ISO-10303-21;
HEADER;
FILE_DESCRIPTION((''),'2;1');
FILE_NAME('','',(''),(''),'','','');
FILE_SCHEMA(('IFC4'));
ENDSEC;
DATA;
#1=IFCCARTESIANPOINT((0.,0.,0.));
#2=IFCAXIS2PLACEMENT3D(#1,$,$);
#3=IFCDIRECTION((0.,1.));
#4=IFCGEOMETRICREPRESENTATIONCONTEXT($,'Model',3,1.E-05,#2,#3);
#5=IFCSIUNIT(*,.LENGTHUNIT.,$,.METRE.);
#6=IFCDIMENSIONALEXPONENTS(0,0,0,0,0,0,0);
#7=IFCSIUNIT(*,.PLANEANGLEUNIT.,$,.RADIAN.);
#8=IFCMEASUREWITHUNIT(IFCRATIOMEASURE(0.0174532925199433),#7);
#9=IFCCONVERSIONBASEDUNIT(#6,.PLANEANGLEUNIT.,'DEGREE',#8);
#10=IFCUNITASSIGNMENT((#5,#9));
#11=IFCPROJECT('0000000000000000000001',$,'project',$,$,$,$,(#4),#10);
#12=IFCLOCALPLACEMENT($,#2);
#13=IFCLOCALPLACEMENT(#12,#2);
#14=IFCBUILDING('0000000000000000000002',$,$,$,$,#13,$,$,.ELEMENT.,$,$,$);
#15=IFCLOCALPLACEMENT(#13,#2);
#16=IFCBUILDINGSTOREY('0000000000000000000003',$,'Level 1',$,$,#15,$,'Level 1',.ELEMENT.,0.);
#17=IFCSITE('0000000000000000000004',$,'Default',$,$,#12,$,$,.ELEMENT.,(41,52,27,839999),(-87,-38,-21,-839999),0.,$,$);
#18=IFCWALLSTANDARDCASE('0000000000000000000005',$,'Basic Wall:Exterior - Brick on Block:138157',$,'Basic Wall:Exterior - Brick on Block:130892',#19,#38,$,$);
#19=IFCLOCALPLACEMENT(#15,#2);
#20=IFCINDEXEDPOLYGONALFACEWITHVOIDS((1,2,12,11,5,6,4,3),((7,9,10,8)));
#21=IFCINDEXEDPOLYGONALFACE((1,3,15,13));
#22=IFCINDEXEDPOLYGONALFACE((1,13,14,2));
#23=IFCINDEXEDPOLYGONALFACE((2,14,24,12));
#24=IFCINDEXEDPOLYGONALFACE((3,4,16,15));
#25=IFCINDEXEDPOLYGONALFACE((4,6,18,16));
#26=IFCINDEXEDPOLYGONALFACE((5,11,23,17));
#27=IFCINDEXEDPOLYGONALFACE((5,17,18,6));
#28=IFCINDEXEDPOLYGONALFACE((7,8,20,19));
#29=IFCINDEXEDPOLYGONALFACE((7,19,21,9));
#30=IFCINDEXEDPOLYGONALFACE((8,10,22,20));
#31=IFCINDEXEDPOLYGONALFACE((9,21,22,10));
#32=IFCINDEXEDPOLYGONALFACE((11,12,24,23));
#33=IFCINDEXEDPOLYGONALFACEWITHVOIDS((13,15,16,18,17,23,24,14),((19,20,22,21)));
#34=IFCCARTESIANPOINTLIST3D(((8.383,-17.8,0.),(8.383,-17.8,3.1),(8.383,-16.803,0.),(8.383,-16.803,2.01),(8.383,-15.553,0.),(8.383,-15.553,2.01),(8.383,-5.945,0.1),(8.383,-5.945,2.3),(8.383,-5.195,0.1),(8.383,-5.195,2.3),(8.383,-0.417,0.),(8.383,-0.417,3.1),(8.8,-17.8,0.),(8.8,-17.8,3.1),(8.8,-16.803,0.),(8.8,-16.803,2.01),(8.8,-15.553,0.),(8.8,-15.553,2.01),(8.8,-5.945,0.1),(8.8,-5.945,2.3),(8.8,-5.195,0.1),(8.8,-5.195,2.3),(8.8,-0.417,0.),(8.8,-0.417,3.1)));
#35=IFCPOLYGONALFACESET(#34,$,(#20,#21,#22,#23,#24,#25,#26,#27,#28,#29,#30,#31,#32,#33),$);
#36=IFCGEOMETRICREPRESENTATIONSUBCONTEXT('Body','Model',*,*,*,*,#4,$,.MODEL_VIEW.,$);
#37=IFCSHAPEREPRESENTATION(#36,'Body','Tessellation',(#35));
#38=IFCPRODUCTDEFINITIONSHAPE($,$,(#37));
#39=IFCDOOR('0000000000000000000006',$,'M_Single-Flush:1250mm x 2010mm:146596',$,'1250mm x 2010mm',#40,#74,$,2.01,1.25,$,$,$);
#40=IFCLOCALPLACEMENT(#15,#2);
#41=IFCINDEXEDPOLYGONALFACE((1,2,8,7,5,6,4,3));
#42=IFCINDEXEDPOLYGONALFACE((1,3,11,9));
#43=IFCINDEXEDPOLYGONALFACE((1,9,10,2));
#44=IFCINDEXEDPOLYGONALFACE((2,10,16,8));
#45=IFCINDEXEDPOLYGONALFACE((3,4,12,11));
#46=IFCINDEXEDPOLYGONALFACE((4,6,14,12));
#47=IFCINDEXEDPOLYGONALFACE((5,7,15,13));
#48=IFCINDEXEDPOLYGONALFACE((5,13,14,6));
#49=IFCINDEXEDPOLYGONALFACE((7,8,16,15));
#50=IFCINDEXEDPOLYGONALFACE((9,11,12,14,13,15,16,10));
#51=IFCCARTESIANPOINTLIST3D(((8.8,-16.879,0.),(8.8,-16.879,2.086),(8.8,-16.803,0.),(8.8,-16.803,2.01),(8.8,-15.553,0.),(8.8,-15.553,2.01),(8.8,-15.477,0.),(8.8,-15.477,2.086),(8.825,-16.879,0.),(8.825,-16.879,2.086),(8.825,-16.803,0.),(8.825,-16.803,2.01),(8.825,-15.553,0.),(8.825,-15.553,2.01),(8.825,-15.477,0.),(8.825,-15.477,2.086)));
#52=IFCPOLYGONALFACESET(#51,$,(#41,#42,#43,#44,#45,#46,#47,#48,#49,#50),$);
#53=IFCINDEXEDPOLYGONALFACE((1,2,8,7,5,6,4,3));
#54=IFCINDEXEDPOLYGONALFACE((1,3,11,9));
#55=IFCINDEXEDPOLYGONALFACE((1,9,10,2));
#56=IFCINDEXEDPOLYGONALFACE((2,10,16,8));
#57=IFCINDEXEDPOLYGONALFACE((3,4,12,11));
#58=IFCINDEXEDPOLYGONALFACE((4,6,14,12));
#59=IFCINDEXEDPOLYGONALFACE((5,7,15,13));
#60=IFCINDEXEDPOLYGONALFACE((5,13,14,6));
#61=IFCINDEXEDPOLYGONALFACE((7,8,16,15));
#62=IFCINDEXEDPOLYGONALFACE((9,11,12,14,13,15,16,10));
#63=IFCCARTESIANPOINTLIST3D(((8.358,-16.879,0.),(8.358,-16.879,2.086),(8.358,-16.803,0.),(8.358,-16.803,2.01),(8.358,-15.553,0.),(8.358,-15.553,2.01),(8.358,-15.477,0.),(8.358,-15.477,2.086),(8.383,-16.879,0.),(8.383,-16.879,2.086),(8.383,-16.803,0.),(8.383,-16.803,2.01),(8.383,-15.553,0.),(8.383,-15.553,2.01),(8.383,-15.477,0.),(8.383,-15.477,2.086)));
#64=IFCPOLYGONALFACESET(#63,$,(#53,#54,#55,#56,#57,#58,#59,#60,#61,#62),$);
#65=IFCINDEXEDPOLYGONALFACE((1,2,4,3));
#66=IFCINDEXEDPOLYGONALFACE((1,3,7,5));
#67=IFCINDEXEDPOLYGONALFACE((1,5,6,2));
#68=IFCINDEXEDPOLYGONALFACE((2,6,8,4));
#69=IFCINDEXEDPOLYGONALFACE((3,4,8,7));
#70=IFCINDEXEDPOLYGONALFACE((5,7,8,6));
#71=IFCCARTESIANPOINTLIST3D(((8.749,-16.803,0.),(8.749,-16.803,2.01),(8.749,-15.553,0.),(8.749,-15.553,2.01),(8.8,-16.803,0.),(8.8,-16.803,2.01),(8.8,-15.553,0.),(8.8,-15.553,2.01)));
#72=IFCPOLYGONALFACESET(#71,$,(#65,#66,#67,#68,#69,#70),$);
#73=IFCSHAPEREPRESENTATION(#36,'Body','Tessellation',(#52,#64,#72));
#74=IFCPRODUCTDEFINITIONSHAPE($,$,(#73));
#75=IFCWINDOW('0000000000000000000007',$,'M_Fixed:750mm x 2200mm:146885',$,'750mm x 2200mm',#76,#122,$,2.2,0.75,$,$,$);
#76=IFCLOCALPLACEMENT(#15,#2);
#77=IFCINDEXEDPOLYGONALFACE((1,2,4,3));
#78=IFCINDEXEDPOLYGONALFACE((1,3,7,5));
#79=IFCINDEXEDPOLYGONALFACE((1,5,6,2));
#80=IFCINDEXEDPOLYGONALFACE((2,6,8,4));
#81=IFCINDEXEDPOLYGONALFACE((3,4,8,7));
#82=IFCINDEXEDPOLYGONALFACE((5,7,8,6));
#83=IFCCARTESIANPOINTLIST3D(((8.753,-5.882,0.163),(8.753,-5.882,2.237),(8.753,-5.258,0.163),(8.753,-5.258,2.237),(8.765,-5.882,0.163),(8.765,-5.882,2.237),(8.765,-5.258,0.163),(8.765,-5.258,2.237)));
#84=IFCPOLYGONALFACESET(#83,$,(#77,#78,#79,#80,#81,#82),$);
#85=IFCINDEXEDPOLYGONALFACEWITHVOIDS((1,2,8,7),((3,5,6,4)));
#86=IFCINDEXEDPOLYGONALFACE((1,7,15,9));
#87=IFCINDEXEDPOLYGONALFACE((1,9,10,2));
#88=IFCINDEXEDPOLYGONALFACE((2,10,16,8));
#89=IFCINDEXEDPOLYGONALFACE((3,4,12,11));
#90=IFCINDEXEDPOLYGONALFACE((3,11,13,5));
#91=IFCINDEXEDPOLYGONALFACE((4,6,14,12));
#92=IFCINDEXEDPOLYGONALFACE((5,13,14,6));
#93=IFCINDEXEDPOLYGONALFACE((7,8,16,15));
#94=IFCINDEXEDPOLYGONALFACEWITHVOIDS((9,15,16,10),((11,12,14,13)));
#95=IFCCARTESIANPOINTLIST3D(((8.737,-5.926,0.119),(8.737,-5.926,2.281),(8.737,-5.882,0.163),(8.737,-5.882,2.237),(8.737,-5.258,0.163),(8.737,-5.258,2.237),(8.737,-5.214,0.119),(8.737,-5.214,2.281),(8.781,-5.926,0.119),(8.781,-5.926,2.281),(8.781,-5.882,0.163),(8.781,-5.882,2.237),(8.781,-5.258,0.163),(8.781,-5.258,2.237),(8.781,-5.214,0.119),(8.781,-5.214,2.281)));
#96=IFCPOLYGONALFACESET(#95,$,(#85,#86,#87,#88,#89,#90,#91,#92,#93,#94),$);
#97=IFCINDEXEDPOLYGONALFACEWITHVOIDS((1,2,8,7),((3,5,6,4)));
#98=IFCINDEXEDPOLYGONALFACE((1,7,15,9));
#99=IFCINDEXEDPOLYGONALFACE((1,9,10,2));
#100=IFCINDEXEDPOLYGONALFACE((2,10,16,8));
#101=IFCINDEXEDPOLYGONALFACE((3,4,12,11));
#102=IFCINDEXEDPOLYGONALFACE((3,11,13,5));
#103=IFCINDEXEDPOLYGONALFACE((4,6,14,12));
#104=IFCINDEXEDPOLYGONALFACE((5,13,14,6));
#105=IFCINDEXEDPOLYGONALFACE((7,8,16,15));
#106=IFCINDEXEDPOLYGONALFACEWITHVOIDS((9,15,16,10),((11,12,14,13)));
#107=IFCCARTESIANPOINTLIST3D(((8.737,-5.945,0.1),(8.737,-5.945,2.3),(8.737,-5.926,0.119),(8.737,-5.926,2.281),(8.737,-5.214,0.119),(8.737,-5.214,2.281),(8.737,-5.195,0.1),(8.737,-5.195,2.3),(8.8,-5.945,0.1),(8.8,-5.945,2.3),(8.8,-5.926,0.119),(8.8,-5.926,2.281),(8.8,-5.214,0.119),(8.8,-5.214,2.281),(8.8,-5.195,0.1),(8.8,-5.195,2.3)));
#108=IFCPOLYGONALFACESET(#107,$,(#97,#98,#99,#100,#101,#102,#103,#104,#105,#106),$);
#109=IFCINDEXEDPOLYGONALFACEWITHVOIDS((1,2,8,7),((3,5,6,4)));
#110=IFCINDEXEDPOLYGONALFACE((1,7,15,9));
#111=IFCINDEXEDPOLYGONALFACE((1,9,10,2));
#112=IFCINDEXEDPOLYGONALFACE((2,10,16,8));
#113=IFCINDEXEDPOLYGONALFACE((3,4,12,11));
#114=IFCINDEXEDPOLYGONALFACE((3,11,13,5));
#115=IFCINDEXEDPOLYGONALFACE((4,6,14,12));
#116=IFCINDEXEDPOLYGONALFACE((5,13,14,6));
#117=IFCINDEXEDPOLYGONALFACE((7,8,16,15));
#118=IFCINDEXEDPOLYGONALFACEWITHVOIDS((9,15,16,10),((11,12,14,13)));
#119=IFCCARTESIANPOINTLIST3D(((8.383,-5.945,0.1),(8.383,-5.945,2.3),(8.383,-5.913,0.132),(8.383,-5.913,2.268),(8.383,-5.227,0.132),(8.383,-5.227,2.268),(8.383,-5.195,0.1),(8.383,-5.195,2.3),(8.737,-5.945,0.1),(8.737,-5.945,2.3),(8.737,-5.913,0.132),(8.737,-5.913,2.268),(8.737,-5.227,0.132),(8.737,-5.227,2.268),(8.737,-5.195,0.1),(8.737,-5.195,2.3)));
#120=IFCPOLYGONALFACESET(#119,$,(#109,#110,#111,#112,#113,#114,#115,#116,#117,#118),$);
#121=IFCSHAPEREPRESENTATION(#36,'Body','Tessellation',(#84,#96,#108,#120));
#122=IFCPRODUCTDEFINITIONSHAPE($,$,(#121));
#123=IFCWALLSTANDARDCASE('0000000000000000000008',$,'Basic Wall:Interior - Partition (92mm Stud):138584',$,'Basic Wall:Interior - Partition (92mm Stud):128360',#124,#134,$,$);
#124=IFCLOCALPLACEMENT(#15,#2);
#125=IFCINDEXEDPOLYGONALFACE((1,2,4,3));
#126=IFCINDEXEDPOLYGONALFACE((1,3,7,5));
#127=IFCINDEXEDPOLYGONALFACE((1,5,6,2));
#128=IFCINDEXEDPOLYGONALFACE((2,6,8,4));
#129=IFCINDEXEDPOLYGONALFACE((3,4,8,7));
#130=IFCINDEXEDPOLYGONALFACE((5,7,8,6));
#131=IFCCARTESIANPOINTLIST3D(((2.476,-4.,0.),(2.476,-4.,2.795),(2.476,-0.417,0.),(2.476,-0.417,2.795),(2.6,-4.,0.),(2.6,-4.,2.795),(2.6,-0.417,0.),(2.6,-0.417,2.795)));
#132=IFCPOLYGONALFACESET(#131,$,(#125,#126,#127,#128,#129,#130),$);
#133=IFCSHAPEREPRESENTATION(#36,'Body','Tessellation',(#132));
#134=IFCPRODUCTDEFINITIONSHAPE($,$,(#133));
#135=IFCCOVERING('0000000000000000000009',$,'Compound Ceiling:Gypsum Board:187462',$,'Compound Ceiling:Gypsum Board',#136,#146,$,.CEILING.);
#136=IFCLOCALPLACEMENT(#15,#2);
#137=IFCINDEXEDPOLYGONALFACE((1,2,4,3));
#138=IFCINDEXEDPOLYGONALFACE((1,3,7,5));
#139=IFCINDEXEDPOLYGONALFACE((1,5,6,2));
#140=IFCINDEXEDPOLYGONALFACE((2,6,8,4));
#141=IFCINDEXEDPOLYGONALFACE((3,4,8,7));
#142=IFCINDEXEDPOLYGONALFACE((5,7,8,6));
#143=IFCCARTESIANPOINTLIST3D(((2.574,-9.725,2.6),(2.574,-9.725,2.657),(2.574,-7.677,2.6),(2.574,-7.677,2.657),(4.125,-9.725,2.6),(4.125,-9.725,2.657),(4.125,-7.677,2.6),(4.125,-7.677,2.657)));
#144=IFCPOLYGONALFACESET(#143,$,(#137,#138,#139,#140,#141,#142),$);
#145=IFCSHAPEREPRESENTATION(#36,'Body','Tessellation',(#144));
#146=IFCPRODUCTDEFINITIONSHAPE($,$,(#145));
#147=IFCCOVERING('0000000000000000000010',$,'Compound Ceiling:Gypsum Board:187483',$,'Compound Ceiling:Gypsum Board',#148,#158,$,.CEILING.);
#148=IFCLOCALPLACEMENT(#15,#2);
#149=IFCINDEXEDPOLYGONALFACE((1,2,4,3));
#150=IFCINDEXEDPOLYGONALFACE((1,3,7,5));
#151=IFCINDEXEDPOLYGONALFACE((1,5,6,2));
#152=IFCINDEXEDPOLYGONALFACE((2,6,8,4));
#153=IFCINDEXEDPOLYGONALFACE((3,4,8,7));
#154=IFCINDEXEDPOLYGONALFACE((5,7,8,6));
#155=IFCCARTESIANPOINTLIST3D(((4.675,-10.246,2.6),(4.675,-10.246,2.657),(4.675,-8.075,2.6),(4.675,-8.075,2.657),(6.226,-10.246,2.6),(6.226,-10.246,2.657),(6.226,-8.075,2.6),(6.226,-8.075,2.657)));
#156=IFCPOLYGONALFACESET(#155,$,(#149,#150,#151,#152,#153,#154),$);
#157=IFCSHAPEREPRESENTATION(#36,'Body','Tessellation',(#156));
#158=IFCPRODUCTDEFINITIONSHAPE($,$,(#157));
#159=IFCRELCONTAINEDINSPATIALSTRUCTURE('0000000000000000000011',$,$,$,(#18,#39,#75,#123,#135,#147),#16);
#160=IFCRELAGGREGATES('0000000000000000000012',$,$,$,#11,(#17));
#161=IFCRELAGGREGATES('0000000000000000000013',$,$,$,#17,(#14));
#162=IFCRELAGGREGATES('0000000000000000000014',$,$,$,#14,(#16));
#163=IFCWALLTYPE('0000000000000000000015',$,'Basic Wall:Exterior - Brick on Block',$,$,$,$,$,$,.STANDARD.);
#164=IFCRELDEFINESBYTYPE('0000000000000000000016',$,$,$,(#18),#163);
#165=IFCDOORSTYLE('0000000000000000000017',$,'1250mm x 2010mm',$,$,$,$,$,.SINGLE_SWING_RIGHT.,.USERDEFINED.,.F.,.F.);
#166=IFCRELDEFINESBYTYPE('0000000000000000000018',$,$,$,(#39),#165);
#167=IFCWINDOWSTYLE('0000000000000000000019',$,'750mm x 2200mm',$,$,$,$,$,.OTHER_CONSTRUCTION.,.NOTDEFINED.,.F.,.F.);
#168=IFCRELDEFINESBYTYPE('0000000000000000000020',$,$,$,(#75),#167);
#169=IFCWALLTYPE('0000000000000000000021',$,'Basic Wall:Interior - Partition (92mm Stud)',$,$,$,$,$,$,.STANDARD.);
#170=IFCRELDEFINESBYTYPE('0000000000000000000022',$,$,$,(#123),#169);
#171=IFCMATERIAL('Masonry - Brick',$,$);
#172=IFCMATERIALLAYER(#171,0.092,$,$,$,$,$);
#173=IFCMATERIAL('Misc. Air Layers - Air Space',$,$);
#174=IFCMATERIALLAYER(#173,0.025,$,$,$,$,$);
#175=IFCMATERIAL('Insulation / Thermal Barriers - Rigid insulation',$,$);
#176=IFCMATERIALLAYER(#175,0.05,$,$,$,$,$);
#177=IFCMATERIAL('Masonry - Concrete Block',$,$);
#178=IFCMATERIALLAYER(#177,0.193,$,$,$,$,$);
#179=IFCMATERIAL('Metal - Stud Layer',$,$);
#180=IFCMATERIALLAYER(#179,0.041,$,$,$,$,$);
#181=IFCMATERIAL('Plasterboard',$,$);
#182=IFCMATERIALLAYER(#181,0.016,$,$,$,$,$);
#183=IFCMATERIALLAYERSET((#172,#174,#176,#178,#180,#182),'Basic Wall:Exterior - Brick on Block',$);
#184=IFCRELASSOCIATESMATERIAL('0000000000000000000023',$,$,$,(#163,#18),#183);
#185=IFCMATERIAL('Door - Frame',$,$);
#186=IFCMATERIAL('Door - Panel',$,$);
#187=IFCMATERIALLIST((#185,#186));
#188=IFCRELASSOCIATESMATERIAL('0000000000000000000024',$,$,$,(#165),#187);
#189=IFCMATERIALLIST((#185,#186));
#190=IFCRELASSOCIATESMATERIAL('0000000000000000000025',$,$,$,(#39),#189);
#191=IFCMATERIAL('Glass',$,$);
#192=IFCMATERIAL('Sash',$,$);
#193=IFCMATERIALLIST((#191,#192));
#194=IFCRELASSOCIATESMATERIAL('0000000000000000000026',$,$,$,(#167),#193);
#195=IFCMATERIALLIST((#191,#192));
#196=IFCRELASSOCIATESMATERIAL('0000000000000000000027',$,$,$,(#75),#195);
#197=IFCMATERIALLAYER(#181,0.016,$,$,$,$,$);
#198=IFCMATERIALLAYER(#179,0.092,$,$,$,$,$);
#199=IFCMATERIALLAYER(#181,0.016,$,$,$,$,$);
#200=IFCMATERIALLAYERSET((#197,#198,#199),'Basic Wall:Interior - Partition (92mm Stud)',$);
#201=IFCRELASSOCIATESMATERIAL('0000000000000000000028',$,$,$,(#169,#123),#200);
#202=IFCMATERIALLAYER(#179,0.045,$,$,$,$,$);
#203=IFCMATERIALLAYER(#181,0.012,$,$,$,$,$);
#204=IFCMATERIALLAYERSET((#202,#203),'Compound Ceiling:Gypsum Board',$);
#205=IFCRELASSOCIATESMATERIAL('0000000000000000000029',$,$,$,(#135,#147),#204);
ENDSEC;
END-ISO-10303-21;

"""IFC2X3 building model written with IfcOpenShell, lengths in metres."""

from ifc_helpers import new_model, entity, si_unit, converted_unit, direction, frame, frame_2d, origin, origin_2d_with_axis, place, context, subcontext, project, spatial, polyline, rectangle, outline, extrude, source, transform, mapped, material, material_list, layer, layer_set, layer_usage, type_object, type_shapes, element, fill, save


model = new_model("IFC2X3")

# Units and contexts
model_context = context("Model", 3, precision=1e-05, world=origin(), true_north=direction((0.0, 1.0)))
body_context = subcontext(model_context, "Body", "Model", "MODEL_VIEW")
ifc_project = project(units=[si_unit("LENGTHUNIT", "METRE"), converted_unit("PLANEANGLEUNIT", "DEGREE", entity("IfcRatioMeasure", 0.0174532925199433), si_unit("PLANEANGLEUNIT", "RADIAN"), dimensions=[0, 0, 0, 0, 0, 0, 0])], contexts=[model_context])

# Site, building, storey
site_placement = place(None, origin())
site = spatial("IfcSite", under=ifc_project, at=site_placement, Name="Default", CompositionType="ELEMENT", RefLatitude=(41, 52, 27, 839999), RefLongitude=(-87, -38, -21, -839999), RefElevation=0.0)
building_placement = place(site_placement, origin())
building = spatial("IfcBuilding", under=site, at=building_placement, CompositionType="ELEMENT")
storey_placement = place(building_placement, origin())
storey = spatial("IfcBuildingStorey", under=building, at=storey_placement, Name="Level 1", LongName="Level 1", CompositionType="ELEMENT", Elevation=0.0)

# Shared definitions
ifc_material_1 = material(Name="Masonry - Brick")
ifc_layer_1 = layer(ifc_material_1, 0.092)
ifc_material_2 = material(Name="Misc. Air Layers - Air Space")
ifc_layer_2 = layer(ifc_material_2, 0.025)
ifc_material_3 = material(Name="Insulation / Thermal Barriers - Rigid insulation")
ifc_layer_3 = layer(ifc_material_3, 0.05)
ifc_material_4 = material(Name="Masonry - Concrete Block")
ifc_layer_4 = layer(ifc_material_4, 0.193)
ifc_material_5 = material(Name="Metal - Stud Layer")
ifc_layer_5 = layer(ifc_material_5, 0.041)
ifc_material_6 = material(Name="Plasterboard")
ifc_layer_6 = layer(ifc_material_6, 0.016)
ifc_layer_set_1 = layer_set([ifc_layer_1, ifc_layer_2, ifc_layer_3, ifc_layer_4, ifc_layer_5, ifc_layer_6], Name="Basic Wall:Exterior - Brick on Block")
wall_type_1 = type_object("IfcWallType", Name="Basic Wall:Exterior - Brick on Block", PredefinedType="STANDARD", material=ifc_layer_set_1)
ifc_material_7 = material(Name="Glass")
ifc_material_8 = material(Name="Sash")
ifc_material_9 = material(Name="Door - Frame")
ifc_material_10 = material(Name="Door - Panel")

# Wall, openings, door, window
ifc_layer_usage_1 = layer_usage(ifc_layer_set_1, "AXIS2", "NEGATIVE", 0.2085)
wall_1_placement = place(storey_placement, frame((8.5915, -0.417, 0.0), z_axis=(0.0, 0.0, 1.0), x_axis=(0.0, -1.0, 0.0)))
wall_1 = element("IfcWallStandardCase", 1, at=wall_1_placement, inside=storey, type_object=wall_type_1, material=ifc_layer_usage_1, Name="Basic Wall:Exterior - Brick on Block:138157", ObjectType="Basic Wall:Exterior - Brick on Block:130892", context=body_context, shape_type="SweptSolid", body=[
    extrude(rectangle(XDim=17.383, YDim=0.417, at=frame_2d((8.6915, 0.0), x_axis=(-1.0, 0.0))), origin(), (0.0, 0.0, 1.0), 3.1),
])
opening_1_placement = place(wall_1_placement, frame((15.136, -0.2085, 0.0)))
opening_1 = element("IfcOpeningElement", 2, at=opening_1_placement, cuts=wall_1, ObjectType="Opening", context=body_context, shape_type="SweptSolid", body=[
    extrude(rectangle(XDim=1.25, YDim=2.01, at=frame_2d((1.005, 0.625), x_axis=(0.0, 1.0))), frame((0.0, 0.0, 0.0), z_axis=(0.0, 1.0, 0.0), x_axis=(0.0, 0.0, 1.0)), (0.0, 0.0, 1.0), 0.417),
])
opening_2_placement = place(wall_1_placement, frame((4.778, -0.2085, 0.1)))
opening_2 = element("IfcOpeningElement", 3, at=opening_2_placement, cuts=wall_1, ObjectType="Opening", context=body_context, shape_type="SweptSolid", body=[
    extrude(rectangle(XDim=2.2, YDim=0.75, at=frame_2d((1.1, 0.375), x_axis=(1.0, 0.0))), frame((0.0, 0.0, 0.0), z_axis=(0.0, 1.0, 0.0), x_axis=(0.0, 0.0, 1.0)), (0.0, 0.0, 1.0), 0.417),
])
ifc_material_list_1 = material_list([ifc_material_9, ifc_material_10])
ifc_material_list_2 = material_list([ifc_material_9, ifc_material_10])
door_style_1 = type_object("IfcDoorStyle", Name="1250mm x 2010mm", ConstructionType="USERDEFINED", OperationType="SINGLE_SWING_RIGHT", ParameterTakesPrecedence=False, Sizeable=False, material=ifc_material_list_2)
shared_shape_1 = source(origin(), body_context, "Body", "SweptSolid", [
    extrude(outline(polyline([(-0.701, -1.062), (0.701, -1.062), (0.701, 1.024), (0.625, 1.024), (0.625, -0.986), (-0.625, -0.986), (-0.625, 1.024), (-0.701, 1.024), (-0.701, -1.062)])), frame((0.625, 0.417, 1.024), z_axis=(0.0, 1.0, 0.0), x_axis=(1.0, 0.0, 0.0)), (0.0, 0.0, 1.0), 0.025),
    extrude(outline(polyline([(-1.062, -0.701), (1.024, -0.701), (1.024, -0.625), (-0.986, -0.625), (-0.986, 0.625), (1.024, 0.625), (1.024, 0.701), (-1.062, 0.701), (-1.062, -0.701)])), frame((0.625, -0.025, 1.024), z_axis=(0.0, 1.0, 0.0), x_axis=(0.0, 0.0, -1.0)), (0.0, 0.0, 1.0), 0.025),
    extrude(rectangle(XDim=0.051, YDim=1.25, at=frame_2d((0.0, 0.0), x_axis=(1.0, 0.0))), frame((0.625, 0.3915, 0.0), z_axis=(0.0, 0.0, 1.0), x_axis=(0.0, 1.0, 0.0)), (0.0, 0.0, 1.0), 2.01),
])
type_shapes(door_style_1, [shared_shape_1])
door_1_placement = place(opening_1_placement, origin())
door_1 = element("IfcDoor", 4, at=door_1_placement, inside=storey, type_object=door_style_1, material=ifc_material_list_1, Name="M_Single-Flush:1250mm x 2010mm:146596", ObjectType="1250mm x 2010mm", OverallHeight=2.01, OverallWidth=1.25, context=body_context, shape_type="MappedRepresentation", body=[
    mapped(shared_shape_1, transform((0.0, 0.0, 0.0), scale=1.0)),
])
fill(opening_1, door_1)
ifc_material_list_3 = material_list([ifc_material_7, ifc_material_8])
ifc_material_list_4 = material_list([ifc_material_7, ifc_material_8])
window_style_1 = type_object("IfcWindowStyle", Name="750mm x 2200mm", ConstructionType="OTHER_CONSTRUCTION", OperationType="NOTDEFINED", ParameterTakesPrecedence=False, Sizeable=False, material=ifc_material_list_4)
shared_shape_2 = source(origin(), body_context, "Body", "SweptSolid", [
    extrude(rectangle(XDim=0.012, YDim=0.624, at=origin_2d_with_axis()), frame((0.375, 0.376, 0.063), z_axis=(0.0, 0.0, 1.0), x_axis=(0.0, -1.0, 0.0)), (0.0, 0.0, 1.0), 2.074),
    extrude(outline(polyline([(-0.356, -1.081), (0.356, -1.081), (0.356, 1.081), (-0.356, 1.081), (-0.356, -1.081)]), holes=[polyline([(-0.312, -1.037), (-0.312, 1.037), (0.312, 1.037), (0.312, -1.037), (-0.312, -1.037)])]), frame((0.375, 0.354, 1.1), z_axis=(0.0, 1.0, 0.0), x_axis=(1.0, 0.0, 0.0)), (0.0, 0.0, 1.0), 0.044),
    extrude(outline(polyline([(-0.375, -1.1), (0.375, -1.1), (0.375, 1.1), (-0.375, 1.1), (-0.375, -1.1)]), holes=[polyline([(-0.356, -1.081), (-0.356, 1.081), (0.356, 1.081), (0.356, -1.081), (-0.356, -1.081)])]), frame((0.375, 0.354, 1.1), z_axis=(0.0, 1.0, 0.0), x_axis=(1.0, 0.0, 0.0)), (0.0, 0.0, 1.0), 0.063),
    extrude(outline(polyline([(-0.375, -1.1), (0.375, -1.1), (0.375, 1.1), (-0.375, 1.1), (-0.375, -1.1)]), holes=[polyline([(-0.343, -1.068), (-0.343, 1.068), (0.343, 1.068), (0.343, -1.068), (-0.343, -1.068)])]), frame((0.375, 0.0, 1.1), z_axis=(0.0, 1.0, 0.0), x_axis=(1.0, 0.0, 0.0)), (0.0, 0.0, 1.0), 0.354),
])
type_shapes(window_style_1, [shared_shape_2])
window_1_placement = place(opening_2_placement, origin())
window_1 = element("IfcWindow", 5, at=window_1_placement, inside=storey, type_object=window_style_1, material=ifc_material_list_3, Name="M_Fixed:750mm x 2200mm:146885", ObjectType="750mm x 2200mm", OverallHeight=2.2, OverallWidth=0.75, context=body_context, shape_type="MappedRepresentation", body=[
    mapped(shared_shape_2, transform((0.0, 0.0, 0.0), scale=1.0)),
])
fill(opening_2, window_1)

# Wall
ifc_layer_7 = layer(ifc_material_6, 0.016)
ifc_layer_8 = layer(ifc_material_5, 0.092)
ifc_layer_9 = layer(ifc_material_6, 0.016)
ifc_layer_set_2 = layer_set([ifc_layer_7, ifc_layer_8, ifc_layer_9], Name="Basic Wall:Interior - Partition (92mm Stud)")
ifc_layer_usage_2 = layer_usage(ifc_layer_set_2, "AXIS2", "NEGATIVE", 0.062)
wall_type_2 = type_object("IfcWallType", Name="Basic Wall:Interior - Partition (92mm Stud)", PredefinedType="STANDARD", material=ifc_layer_set_2)
wall_2_placement = place(storey_placement, frame((2.538, -0.417, 0.0), z_axis=(0.0, 0.0, 1.0), x_axis=(0.0, -1.0, 0.0)))
element("IfcWallStandardCase", 6, at=wall_2_placement, inside=storey, type_object=wall_type_2, material=ifc_layer_usage_2, Name="Basic Wall:Interior - Partition (92mm Stud):138584", ObjectType="Basic Wall:Interior - Partition (92mm Stud):128360", context=body_context, shape_type="SweptSolid", body=[
    extrude(rectangle(XDim=3.583, YDim=0.124, at=frame_2d((1.7915, 0.0), x_axis=(-1.0, 0.0))), origin(), (0.0, 0.0, 1.0), 2.795),
])

# Coverings
ifc_layer_10 = layer(ifc_material_5, 0.045)
ifc_layer_11 = layer(ifc_material_6, 0.012)
ifc_layer_set_3 = layer_set([ifc_layer_10, ifc_layer_11], Name="Compound Ceiling:Gypsum Board")
ifc_layer_usage_3 = layer_usage(ifc_layer_set_3, "AXIS3", "POSITIVE", 0.0)
covering_1_placement = place(storey_placement, origin())
element("IfcCovering", 7, at=covering_1_placement, inside=storey, material=ifc_layer_usage_3, Name="Compound Ceiling:Gypsum Board:187462", ObjectType="Compound Ceiling:Gypsum Board", PredefinedType="CEILING", context=body_context, shape_type="SweptSolid", body=[
    extrude(rectangle(XDim=1.551, YDim=2.048, at=frame_2d((0.0, 0.0), x_axis=(1.0, 0.0))), frame((3.3495, -8.701, 2.6)), (0.0, 0.0, 1.0), 0.057),
])
ifc_layer_usage_4 = layer_usage(ifc_layer_set_3, "AXIS3", "POSITIVE", 0.0)
covering_2_placement = place(storey_placement, origin())
element("IfcCovering", 8, at=covering_2_placement, inside=storey, material=ifc_layer_usage_4, Name="Compound Ceiling:Gypsum Board:187483", ObjectType="Compound Ceiling:Gypsum Board", PredefinedType="CEILING", context=body_context, shape_type="SweptSolid", body=[
    extrude(rectangle(XDim=2.171, YDim=1.551, at=frame_2d((0.0, 0.0), x_axis=(1.0, 0.0))), frame((5.4505, -9.1605, 2.6), z_axis=(0.0, 0.0, 1.0), x_axis=(0.0, -1.0, 0.0)), (0.0, 0.0, 1.0), 0.057),
])

save(model, "model.ifc")
